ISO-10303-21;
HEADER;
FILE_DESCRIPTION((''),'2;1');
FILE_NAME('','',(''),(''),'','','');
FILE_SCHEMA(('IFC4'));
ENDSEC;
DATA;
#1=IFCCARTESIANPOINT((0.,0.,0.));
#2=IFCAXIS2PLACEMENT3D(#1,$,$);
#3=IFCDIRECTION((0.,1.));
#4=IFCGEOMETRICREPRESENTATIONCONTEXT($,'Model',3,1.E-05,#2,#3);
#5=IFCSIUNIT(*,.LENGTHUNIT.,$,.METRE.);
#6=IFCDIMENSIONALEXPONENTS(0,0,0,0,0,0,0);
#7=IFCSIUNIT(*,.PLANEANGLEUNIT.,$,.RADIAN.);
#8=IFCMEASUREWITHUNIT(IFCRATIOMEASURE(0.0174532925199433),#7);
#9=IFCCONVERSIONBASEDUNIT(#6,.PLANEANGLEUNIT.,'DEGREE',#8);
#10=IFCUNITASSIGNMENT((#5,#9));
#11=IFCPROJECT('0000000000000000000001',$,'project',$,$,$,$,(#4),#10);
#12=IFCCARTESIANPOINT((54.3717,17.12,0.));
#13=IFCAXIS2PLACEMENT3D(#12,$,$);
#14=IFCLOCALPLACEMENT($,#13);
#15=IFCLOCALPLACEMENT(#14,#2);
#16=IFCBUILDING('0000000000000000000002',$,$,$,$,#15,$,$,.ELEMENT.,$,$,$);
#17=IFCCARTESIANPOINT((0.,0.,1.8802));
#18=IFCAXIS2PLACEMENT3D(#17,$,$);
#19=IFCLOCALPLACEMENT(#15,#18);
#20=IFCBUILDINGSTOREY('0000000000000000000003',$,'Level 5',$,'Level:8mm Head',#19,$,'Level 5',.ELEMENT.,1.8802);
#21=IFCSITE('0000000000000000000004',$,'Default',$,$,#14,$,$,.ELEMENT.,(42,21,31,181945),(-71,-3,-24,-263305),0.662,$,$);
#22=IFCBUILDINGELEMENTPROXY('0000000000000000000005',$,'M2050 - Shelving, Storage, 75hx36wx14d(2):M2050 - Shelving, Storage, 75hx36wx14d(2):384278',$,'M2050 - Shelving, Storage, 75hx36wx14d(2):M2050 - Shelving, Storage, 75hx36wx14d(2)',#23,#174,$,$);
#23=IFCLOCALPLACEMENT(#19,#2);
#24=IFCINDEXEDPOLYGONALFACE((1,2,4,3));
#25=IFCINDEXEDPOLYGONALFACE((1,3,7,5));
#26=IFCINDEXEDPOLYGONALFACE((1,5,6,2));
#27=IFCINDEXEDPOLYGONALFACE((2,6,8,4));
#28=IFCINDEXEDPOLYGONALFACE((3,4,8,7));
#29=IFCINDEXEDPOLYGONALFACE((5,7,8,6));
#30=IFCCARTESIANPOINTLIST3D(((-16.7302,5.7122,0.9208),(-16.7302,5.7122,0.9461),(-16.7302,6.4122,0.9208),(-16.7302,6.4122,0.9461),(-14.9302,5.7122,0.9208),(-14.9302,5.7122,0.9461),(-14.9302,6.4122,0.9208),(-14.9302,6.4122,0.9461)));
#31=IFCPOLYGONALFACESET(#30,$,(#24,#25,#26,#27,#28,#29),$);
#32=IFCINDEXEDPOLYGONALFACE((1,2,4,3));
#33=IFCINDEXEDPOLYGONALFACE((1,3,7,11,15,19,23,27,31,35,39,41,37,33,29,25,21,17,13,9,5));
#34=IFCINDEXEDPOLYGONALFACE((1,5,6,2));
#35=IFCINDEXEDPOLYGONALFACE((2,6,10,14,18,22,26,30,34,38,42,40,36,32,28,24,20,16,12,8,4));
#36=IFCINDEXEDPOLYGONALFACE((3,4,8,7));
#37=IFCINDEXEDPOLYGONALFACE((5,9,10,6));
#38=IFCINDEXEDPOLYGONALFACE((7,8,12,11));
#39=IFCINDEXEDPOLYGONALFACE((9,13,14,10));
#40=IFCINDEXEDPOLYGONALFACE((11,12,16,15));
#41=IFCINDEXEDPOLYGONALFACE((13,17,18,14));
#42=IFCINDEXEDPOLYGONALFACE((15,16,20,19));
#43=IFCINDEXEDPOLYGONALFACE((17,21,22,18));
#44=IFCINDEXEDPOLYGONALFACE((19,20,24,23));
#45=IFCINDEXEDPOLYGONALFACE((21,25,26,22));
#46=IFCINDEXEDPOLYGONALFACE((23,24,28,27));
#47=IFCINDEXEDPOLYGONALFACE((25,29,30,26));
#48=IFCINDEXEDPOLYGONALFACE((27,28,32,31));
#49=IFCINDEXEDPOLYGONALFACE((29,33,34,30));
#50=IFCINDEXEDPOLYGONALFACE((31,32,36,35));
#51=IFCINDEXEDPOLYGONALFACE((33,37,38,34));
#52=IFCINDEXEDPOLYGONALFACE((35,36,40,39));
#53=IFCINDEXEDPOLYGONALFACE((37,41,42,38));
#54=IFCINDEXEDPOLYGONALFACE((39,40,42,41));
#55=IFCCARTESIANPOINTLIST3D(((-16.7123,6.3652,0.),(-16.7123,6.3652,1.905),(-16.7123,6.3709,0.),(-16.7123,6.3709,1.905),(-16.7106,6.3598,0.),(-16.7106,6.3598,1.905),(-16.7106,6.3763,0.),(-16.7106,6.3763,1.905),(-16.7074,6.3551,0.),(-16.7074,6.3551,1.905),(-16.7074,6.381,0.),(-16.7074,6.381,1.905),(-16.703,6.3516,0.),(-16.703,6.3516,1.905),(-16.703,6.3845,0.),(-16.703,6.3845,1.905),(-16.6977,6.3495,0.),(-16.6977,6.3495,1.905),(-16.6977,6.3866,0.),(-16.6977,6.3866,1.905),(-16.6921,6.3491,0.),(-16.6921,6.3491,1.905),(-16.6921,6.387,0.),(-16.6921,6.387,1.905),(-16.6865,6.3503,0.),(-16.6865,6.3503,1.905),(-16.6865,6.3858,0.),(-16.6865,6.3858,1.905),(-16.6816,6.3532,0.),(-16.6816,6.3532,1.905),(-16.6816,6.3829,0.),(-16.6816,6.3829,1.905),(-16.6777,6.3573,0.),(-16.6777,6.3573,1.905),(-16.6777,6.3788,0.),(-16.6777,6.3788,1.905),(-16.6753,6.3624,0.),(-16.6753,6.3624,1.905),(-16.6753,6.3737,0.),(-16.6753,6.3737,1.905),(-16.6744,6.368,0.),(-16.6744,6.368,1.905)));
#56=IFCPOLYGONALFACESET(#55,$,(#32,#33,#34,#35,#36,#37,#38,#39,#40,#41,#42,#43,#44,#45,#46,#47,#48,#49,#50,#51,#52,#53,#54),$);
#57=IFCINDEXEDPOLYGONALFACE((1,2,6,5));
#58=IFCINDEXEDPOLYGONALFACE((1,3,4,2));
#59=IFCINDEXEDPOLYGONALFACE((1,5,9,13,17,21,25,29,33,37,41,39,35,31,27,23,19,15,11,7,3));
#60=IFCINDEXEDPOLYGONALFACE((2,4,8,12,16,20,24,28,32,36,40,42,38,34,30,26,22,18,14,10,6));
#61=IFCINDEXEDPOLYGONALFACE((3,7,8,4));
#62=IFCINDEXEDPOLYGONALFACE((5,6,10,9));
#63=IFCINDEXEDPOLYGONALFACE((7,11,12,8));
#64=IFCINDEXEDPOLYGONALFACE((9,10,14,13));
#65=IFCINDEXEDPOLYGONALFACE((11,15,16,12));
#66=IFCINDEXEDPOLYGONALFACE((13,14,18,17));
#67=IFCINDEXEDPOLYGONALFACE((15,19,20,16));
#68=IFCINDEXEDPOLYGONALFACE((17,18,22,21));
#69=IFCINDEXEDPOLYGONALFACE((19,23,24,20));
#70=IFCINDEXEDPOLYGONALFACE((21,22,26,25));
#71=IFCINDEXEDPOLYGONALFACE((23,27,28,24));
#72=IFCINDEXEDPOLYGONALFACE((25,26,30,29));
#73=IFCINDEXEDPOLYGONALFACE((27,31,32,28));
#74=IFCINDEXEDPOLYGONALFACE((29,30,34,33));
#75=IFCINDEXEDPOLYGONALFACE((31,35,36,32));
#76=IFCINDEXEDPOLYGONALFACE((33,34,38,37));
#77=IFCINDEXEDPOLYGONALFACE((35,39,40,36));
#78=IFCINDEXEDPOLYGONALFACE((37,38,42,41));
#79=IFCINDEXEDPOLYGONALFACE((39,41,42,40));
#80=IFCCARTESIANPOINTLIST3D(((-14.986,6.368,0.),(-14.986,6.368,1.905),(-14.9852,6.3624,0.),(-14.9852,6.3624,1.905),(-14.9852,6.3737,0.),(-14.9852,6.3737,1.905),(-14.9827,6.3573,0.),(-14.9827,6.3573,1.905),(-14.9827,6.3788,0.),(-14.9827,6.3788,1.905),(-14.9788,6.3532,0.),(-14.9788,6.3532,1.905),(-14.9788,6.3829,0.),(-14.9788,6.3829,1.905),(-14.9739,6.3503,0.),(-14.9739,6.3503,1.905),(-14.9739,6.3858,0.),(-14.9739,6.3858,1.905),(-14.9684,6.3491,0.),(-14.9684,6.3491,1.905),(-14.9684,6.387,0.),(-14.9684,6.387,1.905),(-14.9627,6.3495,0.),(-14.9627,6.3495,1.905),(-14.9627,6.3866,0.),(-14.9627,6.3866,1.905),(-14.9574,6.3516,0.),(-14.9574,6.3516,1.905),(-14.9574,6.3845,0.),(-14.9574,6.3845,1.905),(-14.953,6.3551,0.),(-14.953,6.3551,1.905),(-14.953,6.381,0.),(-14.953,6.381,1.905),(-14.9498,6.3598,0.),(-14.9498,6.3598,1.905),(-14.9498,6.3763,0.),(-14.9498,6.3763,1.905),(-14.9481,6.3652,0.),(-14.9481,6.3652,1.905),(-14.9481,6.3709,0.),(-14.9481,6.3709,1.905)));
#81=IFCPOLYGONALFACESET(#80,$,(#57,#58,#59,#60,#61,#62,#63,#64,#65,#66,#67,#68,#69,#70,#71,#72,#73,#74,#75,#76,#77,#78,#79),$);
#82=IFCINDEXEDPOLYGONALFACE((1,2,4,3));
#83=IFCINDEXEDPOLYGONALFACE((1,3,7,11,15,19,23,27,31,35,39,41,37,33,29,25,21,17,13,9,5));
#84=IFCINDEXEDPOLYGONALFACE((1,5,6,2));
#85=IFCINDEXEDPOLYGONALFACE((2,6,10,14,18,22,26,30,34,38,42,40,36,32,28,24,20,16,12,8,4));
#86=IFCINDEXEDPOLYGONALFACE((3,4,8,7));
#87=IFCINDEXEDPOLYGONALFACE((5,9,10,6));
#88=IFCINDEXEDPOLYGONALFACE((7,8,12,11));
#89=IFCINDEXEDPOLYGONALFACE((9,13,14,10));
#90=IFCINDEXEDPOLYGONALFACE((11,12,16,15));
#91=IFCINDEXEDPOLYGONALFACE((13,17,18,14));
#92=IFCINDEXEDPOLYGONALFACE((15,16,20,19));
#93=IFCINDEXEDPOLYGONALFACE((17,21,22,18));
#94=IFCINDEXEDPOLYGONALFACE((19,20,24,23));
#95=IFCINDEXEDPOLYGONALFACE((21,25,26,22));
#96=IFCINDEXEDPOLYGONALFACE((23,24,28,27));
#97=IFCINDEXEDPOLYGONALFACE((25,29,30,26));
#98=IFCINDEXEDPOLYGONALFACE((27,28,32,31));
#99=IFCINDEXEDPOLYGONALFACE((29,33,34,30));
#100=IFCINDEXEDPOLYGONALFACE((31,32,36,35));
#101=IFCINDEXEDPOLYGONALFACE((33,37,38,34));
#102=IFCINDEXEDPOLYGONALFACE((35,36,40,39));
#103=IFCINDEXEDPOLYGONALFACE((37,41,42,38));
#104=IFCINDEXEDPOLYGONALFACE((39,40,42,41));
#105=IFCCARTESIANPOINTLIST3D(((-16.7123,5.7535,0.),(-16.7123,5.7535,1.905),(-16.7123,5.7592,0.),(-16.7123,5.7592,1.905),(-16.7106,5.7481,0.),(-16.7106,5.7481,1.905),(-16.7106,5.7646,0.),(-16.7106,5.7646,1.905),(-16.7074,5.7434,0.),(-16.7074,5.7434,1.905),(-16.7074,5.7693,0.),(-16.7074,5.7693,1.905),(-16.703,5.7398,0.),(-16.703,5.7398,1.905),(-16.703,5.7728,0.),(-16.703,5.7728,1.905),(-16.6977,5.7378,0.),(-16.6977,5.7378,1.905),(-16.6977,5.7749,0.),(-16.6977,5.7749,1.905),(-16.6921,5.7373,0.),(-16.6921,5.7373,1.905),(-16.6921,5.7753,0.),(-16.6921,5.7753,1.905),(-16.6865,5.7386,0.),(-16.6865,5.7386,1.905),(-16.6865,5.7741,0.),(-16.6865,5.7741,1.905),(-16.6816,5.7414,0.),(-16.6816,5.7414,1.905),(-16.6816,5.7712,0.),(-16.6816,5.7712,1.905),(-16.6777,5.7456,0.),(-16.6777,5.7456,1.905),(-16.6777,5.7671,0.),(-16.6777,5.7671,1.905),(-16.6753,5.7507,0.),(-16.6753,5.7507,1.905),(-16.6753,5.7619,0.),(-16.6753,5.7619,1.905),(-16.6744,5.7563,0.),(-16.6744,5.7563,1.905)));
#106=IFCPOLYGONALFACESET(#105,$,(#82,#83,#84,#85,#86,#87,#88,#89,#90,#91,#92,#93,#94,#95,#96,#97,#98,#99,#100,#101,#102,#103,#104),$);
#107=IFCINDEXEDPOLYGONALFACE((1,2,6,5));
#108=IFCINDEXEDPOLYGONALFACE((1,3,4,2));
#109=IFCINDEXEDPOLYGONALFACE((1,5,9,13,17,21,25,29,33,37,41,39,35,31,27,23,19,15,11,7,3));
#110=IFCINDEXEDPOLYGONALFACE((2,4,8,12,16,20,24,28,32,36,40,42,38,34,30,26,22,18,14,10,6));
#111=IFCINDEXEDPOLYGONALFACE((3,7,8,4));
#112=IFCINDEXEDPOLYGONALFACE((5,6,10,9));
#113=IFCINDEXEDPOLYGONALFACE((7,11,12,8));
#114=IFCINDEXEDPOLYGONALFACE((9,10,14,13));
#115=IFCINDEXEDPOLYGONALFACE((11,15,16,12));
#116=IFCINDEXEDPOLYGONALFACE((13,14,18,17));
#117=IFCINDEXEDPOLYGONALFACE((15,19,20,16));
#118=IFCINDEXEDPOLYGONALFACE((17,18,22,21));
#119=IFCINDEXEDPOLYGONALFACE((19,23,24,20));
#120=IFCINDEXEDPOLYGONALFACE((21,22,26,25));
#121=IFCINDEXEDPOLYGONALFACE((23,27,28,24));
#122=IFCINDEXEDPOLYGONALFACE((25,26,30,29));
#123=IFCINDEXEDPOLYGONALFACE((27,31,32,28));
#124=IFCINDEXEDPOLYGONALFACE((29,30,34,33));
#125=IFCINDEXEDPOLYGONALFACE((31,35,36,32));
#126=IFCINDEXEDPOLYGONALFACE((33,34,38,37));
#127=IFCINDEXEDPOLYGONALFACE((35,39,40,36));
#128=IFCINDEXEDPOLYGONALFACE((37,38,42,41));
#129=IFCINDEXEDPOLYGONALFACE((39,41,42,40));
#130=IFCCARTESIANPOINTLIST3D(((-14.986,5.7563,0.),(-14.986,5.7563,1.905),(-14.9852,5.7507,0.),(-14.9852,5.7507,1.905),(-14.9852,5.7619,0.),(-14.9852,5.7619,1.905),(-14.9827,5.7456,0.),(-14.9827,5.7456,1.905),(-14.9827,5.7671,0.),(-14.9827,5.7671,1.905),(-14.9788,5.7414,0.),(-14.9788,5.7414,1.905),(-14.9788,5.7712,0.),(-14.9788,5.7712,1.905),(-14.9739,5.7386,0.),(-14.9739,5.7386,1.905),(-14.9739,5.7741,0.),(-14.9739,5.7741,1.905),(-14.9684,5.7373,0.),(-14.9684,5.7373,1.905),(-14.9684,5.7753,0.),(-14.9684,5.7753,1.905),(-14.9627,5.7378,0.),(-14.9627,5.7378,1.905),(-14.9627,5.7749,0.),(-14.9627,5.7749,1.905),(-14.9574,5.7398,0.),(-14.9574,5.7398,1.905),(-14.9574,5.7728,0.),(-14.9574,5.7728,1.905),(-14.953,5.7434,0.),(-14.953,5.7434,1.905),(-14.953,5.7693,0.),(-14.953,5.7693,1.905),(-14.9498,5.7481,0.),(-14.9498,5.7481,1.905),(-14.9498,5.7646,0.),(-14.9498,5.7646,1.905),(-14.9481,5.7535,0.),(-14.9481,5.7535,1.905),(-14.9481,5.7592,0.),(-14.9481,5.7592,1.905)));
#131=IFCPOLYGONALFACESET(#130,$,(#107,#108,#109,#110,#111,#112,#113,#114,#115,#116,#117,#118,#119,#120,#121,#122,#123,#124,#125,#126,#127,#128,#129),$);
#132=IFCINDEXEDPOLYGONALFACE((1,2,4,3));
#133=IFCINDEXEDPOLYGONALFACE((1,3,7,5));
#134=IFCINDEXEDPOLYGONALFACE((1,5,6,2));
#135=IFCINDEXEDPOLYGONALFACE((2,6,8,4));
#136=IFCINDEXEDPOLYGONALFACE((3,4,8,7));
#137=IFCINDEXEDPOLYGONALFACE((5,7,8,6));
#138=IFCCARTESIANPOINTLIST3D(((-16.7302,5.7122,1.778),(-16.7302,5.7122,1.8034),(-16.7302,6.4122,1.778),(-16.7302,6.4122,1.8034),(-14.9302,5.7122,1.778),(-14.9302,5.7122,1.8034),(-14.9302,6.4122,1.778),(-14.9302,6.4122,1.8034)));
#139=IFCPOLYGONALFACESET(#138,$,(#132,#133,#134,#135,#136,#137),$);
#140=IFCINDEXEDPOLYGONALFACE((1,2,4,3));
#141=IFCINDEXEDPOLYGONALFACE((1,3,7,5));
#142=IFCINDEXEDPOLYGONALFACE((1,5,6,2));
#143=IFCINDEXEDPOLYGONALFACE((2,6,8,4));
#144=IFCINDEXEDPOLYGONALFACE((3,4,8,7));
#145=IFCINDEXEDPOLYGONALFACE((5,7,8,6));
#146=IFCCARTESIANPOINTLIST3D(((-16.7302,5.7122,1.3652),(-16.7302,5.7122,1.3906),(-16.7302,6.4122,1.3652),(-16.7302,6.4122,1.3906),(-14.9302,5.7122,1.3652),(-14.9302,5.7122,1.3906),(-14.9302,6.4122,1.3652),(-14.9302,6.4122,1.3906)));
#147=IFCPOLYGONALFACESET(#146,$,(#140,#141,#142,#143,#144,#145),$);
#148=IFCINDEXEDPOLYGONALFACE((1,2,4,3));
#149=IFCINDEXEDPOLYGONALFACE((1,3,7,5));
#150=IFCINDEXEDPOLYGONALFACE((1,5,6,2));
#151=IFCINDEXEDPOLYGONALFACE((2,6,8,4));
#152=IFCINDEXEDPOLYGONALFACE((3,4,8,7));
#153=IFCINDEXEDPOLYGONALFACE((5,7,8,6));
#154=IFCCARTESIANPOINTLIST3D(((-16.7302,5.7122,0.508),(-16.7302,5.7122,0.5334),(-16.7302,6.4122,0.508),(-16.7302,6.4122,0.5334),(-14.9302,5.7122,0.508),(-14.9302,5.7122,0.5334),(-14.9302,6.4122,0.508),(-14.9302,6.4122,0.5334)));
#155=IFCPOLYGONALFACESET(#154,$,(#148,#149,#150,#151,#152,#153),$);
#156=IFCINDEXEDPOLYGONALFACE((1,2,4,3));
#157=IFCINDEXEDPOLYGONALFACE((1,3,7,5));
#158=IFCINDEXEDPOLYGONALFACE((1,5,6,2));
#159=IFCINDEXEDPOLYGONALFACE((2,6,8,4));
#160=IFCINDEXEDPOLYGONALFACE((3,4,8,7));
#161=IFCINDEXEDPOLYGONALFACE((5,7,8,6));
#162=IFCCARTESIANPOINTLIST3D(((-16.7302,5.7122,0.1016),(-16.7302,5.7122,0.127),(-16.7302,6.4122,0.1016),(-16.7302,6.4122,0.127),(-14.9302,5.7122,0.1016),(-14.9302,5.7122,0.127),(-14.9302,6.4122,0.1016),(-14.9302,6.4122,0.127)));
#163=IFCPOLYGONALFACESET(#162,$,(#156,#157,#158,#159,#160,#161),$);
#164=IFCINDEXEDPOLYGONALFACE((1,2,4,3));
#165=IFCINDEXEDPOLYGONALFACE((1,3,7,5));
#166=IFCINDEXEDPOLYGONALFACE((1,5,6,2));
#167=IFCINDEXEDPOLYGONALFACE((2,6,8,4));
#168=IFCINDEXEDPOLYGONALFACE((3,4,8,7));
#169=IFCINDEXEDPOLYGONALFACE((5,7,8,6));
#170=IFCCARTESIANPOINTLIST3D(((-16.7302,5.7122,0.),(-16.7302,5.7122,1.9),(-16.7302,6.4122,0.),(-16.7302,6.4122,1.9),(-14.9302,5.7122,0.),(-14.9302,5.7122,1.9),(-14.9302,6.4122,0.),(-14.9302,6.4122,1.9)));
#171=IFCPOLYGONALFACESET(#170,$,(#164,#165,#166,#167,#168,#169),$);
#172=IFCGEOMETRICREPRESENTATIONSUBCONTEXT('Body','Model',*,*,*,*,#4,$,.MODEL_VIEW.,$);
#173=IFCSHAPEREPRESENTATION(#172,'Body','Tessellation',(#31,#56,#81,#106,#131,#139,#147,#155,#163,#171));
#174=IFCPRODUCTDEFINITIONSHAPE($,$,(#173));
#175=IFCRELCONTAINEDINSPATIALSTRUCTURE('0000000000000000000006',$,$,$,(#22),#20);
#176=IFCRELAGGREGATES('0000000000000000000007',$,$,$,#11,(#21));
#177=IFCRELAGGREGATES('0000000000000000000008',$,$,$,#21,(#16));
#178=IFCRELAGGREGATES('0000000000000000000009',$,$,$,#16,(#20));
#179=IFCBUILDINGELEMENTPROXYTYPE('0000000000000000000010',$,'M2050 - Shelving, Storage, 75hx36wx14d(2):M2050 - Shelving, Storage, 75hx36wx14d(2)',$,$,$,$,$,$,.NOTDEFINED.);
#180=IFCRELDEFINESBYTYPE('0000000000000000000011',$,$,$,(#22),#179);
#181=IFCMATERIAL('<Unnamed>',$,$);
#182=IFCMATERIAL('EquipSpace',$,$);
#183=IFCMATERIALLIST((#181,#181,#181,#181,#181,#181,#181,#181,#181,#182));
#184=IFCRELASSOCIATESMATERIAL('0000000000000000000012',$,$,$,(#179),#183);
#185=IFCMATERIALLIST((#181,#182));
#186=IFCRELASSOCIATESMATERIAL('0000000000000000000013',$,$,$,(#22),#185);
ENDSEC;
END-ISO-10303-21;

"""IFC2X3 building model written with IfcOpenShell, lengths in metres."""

from ifc_helpers import new_model, entity, si_unit, converted_unit, direction, frame, frame_2d, origin, origin_2d_with_axis, place, context, subcontext, project, spatial, rectangle, circle, extrude, source, transform, mapped, material, material_list, type_object, type_shapes, element, save


model = new_model("IFC2X3")

# Units and contexts
model_context = context("Model", 3, precision=1e-05, world=origin(), true_north=direction((0.0, 1.0)))
body_context = subcontext(model_context, "Body", "Model", "MODEL_VIEW")
ifc_project = project(units=[si_unit("LENGTHUNIT", "METRE"), converted_unit("PLANEANGLEUNIT", "DEGREE", entity("IfcRatioMeasure", 0.0174532925199433), si_unit("PLANEANGLEUNIT", "RADIAN"), dimensions=[0, 0, 0, 0, 0, 0, 0])], contexts=[model_context])

# Site, building, storey
site_placement = place(None, frame((54.3717, 17.12, 0.0)))
site = spatial("IfcSite", under=ifc_project, at=site_placement, Name="Default", CompositionType="ELEMENT", RefLatitude=(42, 21, 31, 181945), RefLongitude=(-71, -3, -24, -263305), RefElevation=0.662)
building_placement = place(site_placement, origin())
building = spatial("IfcBuilding", under=site, at=building_placement, CompositionType="ELEMENT")
storey_placement = place(building_placement, frame((0.0, 0.0, 1.8802)))
storey = spatial("IfcBuildingStorey", under=building, at=storey_placement, Name="Level 5", ObjectType="Level:8mm Head", LongName="Level 5", CompositionType="ELEMENT", Elevation=1.8802)

# Building element proxy
ifc_material_1 = material(Name="<Unnamed>")
ifc_material_2 = material(Name="EquipSpace")
ifc_material_list_1 = material_list([ifc_material_1, ifc_material_1, ifc_material_1, ifc_material_1, ifc_material_1, ifc_material_1, ifc_material_1, ifc_material_1, ifc_material_1, ifc_material_2])
building_element_proxy_type = type_object("IfcBuildingElementProxyType", Name="M2050 - Shelving, Storage, 75hx36wx14d(2):M2050 - Shelving, Storage, 75hx36wx14d(2)", PredefinedType="NOTDEFINED", material=ifc_material_list_1)
shared_shape = source(origin(), body_context, "Body", "SweptSolid", [
    extrude(rectangle(XDim=1.8, YDim=0.7, at=origin_2d_with_axis()), frame((0.0, 0.0, 0.9207), z_axis=(0.0, 0.0, 1.0), x_axis=(-1.0, 0.0, 0.0)), (0.0, 0.0, 1.0), 0.0254),
    extrude(circle(Radius=0.0191, at=origin_2d_with_axis()), frame((0.8633, -0.3059, 0.0), z_axis=(0.0, 0.0, 1.0), x_axis=(-1.0, 0.0, 0.0)), (0.0, 0.0, 1.0), 1.905),
    extrude(circle(Radius=0.0191, at=origin_2d_with_axis()), frame((-0.8633, -0.3059, 0.0)), (0.0, 0.0, 1.0), 1.905),
    extrude(circle(Radius=0.0191, at=origin_2d_with_axis()), frame((0.8633, 0.3059, 0.0), z_axis=(0.0, 0.0, 1.0), x_axis=(-1.0, 0.0, 0.0)), (0.0, 0.0, 1.0), 1.905),
    extrude(circle(Radius=0.0191, at=origin_2d_with_axis()), frame((-0.8633, 0.3059, 0.0)), (0.0, 0.0, 1.0), 1.905),
    extrude(rectangle(XDim=1.8, YDim=0.7, at=origin_2d_with_axis()), frame((0.0, 0.0, 1.778), z_axis=(0.0, 0.0, 1.0), x_axis=(-1.0, 0.0, 0.0)), (0.0, 0.0, 1.0), 0.0254),
    extrude(rectangle(XDim=1.8, YDim=0.7, at=origin_2d_with_axis()), frame((0.0, 0.0, 1.3653), z_axis=(0.0, 0.0, 1.0), x_axis=(-1.0, 0.0, 0.0)), (0.0, 0.0, 1.0), 0.0254),
    extrude(rectangle(XDim=1.8, YDim=0.7, at=origin_2d_with_axis()), frame((0.0, 0.0, 0.508), z_axis=(0.0, 0.0, 1.0), x_axis=(-1.0, 0.0, 0.0)), (0.0, 0.0, 1.0), 0.0254),
    extrude(rectangle(XDim=1.8, YDim=0.7, at=origin_2d_with_axis()), frame((0.0, 0.0, 0.1016), z_axis=(0.0, 0.0, 1.0), x_axis=(-1.0, 0.0, 0.0)), (0.0, 0.0, 1.0), 0.0254),
    extrude(rectangle(XDim=0.7, YDim=1.8, at=frame_2d((0.0, 0.18), x_axis=(1.0, 0.0))), frame((-0.18, 0.0, 0.0), z_axis=(0.0, 0.0, 1.0), x_axis=(0.0, -1.0, 0.0)), (0.0, 0.0, 1.0), 1.9),
])
type_shapes(building_element_proxy_type, [shared_shape])
ifc_material_list_2 = material_list([ifc_material_1, ifc_material_2])
proxy_1_placement = place(storey_placement, frame((-15.8302, 6.0622, 0.0), z_axis=(0.0, 0.0, 1.0), x_axis=(-1.0, 0.0, 0.0)))
element("IfcBuildingElementProxy", 1, at=proxy_1_placement, inside=storey, type_object=building_element_proxy_type, material=ifc_material_list_2, Name="M2050 - Shelving, Storage, 75hx36wx14d(2):M2050 - Shelving, Storage, 75hx36wx14d(2):384278", ObjectType="M2050 - Shelving, Storage, 75hx36wx14d(2):M2050 - Shelving, Storage, 75hx36wx14d(2)", context=body_context, shape_type="MappedRepresentation", body=[
    mapped(shared_shape, transform((0.0, 0.0, 0.0), scale=1.0)),
])

save(model, "model.ifc")
